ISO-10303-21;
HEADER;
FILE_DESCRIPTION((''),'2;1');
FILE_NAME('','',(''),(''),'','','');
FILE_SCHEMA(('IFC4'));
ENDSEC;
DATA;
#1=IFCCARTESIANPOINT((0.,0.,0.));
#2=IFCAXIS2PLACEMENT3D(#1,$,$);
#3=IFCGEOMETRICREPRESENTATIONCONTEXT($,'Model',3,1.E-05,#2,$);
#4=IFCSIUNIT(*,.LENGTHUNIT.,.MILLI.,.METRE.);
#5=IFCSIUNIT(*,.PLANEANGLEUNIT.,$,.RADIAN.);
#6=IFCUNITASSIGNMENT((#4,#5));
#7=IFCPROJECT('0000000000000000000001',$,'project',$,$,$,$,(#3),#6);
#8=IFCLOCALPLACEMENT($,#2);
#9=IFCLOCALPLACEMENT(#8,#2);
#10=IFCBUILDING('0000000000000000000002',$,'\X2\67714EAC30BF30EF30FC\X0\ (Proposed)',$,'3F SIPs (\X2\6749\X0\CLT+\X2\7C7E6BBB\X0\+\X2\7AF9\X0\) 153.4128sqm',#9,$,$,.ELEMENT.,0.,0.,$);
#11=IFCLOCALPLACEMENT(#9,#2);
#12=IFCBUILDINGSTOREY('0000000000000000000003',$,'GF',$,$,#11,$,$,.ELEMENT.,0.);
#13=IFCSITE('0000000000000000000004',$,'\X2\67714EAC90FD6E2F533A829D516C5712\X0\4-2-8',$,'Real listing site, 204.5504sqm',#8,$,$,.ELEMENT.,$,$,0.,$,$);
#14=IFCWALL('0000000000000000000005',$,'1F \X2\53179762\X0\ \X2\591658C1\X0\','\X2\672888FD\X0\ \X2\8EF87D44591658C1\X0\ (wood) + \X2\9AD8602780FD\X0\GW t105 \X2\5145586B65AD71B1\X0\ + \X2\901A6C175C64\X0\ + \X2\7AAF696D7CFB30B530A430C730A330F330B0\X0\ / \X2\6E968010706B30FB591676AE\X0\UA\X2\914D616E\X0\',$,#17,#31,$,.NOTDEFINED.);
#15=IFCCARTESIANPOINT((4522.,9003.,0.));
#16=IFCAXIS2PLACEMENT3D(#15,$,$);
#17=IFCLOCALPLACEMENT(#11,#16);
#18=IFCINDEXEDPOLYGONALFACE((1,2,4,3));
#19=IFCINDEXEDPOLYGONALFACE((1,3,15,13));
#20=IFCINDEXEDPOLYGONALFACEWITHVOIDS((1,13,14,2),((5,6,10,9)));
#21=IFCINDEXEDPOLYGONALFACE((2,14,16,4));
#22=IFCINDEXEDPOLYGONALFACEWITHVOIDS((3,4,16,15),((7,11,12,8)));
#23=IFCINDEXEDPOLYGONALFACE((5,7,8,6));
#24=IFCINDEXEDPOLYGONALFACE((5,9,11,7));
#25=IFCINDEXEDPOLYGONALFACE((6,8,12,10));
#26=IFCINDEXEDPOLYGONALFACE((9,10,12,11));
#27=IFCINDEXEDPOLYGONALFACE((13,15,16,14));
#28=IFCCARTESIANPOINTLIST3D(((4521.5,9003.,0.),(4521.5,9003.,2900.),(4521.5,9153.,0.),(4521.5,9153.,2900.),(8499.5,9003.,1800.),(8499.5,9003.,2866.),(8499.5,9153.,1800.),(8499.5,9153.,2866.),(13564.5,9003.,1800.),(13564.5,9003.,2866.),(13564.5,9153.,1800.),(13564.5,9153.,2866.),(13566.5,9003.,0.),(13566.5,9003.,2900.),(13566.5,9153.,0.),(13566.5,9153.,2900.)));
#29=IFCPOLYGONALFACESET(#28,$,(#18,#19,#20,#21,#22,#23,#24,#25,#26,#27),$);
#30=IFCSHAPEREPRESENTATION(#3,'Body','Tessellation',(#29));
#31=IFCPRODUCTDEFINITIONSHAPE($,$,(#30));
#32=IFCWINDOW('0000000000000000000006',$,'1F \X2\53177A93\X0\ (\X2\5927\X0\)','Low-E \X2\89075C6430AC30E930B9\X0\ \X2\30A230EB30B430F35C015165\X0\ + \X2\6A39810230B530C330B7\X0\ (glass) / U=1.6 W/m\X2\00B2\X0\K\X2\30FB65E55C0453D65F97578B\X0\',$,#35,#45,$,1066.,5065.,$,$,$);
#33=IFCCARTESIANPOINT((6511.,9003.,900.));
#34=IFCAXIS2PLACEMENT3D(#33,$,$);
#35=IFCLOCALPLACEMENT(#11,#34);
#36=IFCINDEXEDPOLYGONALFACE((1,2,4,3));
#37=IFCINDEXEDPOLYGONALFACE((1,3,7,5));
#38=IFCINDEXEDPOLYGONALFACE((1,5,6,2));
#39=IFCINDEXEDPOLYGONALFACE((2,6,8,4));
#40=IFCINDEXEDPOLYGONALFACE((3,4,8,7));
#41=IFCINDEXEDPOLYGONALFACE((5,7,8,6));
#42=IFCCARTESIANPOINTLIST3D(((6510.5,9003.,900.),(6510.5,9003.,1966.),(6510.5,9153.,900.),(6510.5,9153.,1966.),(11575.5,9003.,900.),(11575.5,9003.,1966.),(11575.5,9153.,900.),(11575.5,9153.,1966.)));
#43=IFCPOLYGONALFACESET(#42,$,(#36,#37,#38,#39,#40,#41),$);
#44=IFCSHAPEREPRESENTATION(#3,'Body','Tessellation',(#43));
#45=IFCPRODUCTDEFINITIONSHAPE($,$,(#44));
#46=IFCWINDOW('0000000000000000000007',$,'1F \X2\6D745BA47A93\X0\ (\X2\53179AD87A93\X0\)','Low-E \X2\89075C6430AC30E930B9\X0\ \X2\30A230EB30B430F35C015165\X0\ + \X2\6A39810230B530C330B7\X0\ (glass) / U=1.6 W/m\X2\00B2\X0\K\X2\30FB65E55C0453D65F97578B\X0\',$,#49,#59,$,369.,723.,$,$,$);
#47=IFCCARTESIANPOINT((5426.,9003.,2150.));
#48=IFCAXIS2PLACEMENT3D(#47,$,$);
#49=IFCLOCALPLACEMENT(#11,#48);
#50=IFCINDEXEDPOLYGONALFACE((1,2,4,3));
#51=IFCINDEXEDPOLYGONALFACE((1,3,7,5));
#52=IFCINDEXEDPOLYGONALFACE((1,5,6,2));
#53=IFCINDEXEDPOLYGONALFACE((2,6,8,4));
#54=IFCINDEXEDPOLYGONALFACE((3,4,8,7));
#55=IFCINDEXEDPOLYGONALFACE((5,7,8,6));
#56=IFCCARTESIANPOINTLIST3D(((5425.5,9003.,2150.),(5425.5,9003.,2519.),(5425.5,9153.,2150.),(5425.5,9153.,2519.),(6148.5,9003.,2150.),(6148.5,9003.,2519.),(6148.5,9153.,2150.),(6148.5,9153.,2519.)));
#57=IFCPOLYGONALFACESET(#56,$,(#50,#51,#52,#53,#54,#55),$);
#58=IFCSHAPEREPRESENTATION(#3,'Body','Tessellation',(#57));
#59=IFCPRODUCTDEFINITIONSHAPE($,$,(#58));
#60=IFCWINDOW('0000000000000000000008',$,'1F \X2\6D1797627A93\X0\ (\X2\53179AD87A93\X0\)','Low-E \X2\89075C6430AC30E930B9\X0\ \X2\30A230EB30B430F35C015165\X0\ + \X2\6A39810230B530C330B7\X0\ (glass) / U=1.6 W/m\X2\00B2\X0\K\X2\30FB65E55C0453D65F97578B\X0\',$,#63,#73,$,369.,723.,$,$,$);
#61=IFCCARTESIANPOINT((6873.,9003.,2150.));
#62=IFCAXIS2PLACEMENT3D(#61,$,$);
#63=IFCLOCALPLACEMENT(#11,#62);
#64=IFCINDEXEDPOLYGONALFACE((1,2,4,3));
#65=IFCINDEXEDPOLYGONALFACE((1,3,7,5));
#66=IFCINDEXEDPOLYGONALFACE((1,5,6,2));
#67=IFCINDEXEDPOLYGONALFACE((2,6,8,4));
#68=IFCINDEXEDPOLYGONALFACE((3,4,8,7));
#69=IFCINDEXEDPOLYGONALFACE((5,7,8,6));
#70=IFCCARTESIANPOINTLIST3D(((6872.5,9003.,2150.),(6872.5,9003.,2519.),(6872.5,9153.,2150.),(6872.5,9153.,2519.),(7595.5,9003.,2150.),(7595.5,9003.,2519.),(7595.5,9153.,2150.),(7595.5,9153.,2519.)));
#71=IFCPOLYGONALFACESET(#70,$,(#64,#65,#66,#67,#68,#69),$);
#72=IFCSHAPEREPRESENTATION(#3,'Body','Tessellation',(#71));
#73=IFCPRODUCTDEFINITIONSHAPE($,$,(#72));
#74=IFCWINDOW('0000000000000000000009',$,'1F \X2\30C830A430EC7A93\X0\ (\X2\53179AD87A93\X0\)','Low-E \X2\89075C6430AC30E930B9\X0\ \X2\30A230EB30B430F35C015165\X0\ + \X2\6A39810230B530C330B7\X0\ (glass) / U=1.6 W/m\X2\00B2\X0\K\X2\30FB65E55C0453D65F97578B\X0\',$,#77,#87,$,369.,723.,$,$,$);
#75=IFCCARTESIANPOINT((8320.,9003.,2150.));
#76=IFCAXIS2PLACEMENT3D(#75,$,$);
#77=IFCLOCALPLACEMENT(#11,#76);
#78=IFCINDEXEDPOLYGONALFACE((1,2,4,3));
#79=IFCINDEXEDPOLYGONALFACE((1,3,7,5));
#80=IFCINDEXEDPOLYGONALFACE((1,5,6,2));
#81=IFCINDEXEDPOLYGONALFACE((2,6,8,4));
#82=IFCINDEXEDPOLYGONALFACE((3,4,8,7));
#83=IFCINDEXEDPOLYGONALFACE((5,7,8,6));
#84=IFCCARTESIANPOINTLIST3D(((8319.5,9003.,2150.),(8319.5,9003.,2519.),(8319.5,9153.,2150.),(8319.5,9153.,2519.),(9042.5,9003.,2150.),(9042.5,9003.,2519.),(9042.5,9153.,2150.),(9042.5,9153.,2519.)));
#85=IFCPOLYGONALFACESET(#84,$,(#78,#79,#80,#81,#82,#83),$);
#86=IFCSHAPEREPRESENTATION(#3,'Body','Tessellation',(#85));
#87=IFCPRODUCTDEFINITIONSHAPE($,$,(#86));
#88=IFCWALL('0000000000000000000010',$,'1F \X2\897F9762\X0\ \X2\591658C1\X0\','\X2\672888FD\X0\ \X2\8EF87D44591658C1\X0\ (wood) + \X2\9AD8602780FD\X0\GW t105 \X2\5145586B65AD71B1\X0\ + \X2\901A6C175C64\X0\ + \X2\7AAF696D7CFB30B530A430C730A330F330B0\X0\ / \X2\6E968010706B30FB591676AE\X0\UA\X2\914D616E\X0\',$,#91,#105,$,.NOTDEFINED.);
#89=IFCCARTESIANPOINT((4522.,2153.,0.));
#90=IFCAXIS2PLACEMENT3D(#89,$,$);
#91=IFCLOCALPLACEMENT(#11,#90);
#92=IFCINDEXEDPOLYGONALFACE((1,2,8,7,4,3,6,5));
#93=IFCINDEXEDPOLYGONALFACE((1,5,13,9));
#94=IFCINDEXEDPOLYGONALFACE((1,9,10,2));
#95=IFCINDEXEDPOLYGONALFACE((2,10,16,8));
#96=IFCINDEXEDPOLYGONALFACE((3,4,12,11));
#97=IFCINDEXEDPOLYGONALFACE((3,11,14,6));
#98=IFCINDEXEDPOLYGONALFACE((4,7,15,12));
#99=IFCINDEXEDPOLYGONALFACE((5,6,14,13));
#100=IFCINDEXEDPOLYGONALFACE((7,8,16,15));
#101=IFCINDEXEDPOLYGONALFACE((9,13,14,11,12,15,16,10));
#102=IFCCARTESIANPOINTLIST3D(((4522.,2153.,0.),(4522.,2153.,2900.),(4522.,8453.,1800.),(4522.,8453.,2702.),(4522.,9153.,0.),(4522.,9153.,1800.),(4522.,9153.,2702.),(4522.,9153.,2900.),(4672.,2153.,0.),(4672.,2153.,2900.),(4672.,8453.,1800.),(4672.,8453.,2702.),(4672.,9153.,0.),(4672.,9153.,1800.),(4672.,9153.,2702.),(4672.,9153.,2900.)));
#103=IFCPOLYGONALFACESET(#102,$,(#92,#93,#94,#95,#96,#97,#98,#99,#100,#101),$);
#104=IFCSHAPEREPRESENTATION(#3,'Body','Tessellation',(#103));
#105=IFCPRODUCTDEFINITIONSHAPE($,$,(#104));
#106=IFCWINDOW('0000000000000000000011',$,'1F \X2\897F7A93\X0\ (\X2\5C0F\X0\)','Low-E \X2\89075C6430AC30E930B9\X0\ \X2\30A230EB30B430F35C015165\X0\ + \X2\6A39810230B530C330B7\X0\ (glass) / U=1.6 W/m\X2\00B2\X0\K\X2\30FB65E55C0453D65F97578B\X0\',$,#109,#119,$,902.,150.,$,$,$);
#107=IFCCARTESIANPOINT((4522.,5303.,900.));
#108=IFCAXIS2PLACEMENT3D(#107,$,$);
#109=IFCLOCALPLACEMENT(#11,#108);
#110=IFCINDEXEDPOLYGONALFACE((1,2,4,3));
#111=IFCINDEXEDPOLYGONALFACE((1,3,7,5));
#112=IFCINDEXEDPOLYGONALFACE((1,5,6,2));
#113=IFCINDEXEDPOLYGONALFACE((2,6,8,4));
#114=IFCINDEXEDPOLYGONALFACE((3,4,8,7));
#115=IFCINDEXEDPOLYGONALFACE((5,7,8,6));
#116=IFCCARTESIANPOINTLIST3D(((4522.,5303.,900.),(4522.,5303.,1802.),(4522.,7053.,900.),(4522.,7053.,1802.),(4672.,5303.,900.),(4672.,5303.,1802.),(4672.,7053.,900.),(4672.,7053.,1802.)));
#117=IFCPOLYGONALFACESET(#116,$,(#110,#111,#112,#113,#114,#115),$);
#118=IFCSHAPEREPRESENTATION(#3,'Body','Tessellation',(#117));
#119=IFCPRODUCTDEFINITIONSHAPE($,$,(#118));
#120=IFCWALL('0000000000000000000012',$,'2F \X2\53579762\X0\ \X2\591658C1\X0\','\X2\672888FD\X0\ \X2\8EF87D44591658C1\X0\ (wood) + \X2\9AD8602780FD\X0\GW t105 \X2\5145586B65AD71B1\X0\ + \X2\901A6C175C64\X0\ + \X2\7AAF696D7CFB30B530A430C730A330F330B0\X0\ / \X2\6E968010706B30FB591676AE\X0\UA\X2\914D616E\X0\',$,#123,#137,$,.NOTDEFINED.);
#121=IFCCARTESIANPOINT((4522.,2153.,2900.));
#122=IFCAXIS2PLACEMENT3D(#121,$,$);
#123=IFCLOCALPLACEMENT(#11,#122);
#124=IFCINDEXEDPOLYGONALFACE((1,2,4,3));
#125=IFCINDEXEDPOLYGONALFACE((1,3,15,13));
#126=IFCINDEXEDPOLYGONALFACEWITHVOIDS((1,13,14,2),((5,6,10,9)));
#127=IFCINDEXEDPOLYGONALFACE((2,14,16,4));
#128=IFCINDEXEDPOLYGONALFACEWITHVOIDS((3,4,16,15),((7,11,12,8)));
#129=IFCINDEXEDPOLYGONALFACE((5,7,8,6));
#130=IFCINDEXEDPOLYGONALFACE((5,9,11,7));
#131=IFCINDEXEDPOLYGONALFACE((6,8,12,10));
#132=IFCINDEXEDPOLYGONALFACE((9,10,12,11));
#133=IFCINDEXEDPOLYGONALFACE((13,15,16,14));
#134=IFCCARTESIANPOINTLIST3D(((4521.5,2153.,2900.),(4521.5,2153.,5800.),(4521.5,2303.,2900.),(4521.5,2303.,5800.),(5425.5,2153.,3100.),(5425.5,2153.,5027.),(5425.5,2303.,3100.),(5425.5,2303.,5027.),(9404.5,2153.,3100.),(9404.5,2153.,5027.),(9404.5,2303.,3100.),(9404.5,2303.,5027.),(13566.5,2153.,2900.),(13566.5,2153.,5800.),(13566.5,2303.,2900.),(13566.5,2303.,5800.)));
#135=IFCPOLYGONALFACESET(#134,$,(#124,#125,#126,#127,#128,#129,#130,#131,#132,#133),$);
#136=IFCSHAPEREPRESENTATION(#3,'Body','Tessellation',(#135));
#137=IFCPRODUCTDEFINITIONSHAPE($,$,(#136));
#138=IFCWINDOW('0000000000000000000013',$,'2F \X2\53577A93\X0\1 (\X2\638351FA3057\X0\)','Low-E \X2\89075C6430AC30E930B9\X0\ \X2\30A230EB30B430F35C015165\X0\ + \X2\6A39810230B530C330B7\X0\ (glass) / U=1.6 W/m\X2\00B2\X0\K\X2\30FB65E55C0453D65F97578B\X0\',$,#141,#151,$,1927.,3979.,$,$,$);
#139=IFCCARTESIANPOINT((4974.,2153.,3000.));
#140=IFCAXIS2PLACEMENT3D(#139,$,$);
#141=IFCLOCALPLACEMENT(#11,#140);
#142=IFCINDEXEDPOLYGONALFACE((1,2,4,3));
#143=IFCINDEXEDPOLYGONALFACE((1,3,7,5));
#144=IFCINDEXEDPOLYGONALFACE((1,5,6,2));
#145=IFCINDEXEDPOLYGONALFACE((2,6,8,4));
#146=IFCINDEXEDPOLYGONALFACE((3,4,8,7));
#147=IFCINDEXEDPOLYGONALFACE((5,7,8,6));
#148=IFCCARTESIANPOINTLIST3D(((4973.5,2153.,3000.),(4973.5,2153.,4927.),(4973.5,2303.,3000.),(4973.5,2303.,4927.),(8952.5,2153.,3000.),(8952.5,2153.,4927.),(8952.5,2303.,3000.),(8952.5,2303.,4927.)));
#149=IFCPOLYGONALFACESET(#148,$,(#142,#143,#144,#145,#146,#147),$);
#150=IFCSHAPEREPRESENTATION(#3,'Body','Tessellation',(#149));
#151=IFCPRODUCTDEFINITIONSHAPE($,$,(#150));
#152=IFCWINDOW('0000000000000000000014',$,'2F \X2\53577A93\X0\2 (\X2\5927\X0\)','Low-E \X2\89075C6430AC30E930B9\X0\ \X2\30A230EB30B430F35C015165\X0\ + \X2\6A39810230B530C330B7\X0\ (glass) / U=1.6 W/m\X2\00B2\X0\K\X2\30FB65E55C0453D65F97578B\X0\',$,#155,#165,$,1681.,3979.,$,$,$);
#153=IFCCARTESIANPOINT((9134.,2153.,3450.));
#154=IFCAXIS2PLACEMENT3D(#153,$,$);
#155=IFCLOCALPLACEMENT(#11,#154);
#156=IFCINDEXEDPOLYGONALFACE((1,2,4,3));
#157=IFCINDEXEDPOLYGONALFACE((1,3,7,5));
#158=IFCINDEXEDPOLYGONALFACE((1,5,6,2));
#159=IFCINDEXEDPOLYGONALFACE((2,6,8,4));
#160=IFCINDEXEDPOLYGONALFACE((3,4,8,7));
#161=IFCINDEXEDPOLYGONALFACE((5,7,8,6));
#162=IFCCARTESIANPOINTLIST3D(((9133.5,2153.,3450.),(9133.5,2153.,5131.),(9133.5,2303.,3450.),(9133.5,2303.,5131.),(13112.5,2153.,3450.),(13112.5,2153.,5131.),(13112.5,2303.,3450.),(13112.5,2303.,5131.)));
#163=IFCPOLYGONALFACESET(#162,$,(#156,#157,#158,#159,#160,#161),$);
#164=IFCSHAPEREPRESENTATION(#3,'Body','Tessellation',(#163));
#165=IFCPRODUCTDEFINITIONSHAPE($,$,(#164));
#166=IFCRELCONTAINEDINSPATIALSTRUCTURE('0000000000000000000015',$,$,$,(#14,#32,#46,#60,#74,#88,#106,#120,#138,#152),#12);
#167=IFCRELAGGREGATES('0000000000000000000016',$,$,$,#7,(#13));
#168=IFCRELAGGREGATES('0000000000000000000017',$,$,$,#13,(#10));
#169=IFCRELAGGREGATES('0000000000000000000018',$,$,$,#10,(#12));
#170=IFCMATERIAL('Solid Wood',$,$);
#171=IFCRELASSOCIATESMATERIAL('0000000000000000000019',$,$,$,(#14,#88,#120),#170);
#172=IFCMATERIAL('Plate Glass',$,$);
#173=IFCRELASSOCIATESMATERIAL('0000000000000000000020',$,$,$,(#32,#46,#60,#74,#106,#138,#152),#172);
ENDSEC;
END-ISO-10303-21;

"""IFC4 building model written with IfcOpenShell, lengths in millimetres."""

from ifc_helpers import new_model, si_unit, frame, frame_2d, origin, place, context, project, spatial, rectangle, extrude, material, element, fill, save


model = new_model("IFC4")

# Units and contexts
model_context = context("Model", 3, precision=1e-05, world=origin())
ifc_project = project(units=[si_unit("LENGTHUNIT", "METRE", prefix="MILLI"), si_unit("PLANEANGLEUNIT", "RADIAN")], contexts=[model_context])

# Site, building, storey
site_placement = place(None, origin())
site = spatial("IfcSite", under=ifc_project, at=site_placement, Name="東京都港区芝公園4-2-8", ObjectType="Real listing site, 204.5504sqm", CompositionType="ELEMENT", RefElevation=0.0)
building_placement = place(site_placement, origin())
building = spatial("IfcBuilding", under=site, at=building_placement, Name="東京タワー (Proposed)", ObjectType="3F SIPs (杉CLT+籾殻+竹) 153.4128sqm", CompositionType="ELEMENT", ElevationOfRefHeight=0.0, ElevationOfTerrain=0.0)
storey_placement = place(building_placement, origin())
storey = spatial("IfcBuildingStorey", under=building, at=storey_placement, Name="GF", CompositionType="ELEMENT", Elevation=0.0)

# Shared definitions
ifc_material_1 = material(Name="Solid Wood")

# Shared definitions
ifc_material_2 = material(Name="Plate Glass")

# Wall, openings, windows
wall_1_placement = place(storey_placement, frame((4522.0, 9003.0, 0.0)))
wall_1 = element("IfcWall", 1, at=wall_1_placement, inside=storey, material=ifc_material_1, Name="1F 北面 外壁", Description="木製 軸組外壁 (wood) + 高性能GW t105 充填断熱 + 通気層 + 窯業系サイディング / 準耐火・外皮UA配慮", PredefinedType="NOTDEFINED", context=model_context, shape_type="SweptSolid", body=[
    extrude(rectangle(XDim=9045.0, YDim=150.0, at=frame_2d((4522.0, 75.0))), frame((4522.0, 9003.0, 0.0)), (0.0, 0.0, 1.0), 2900.0),
])
opening_1_placement = place(storey_placement, frame((6511.0, 9003.0, 900.0)))
opening_1 = element("IfcOpeningElement", 2, at=opening_1_placement, cuts=wall_1, PredefinedType="NOTDEFINED", context=model_context, shape_type="SweptSolid", body=[
    extrude(rectangle(XDim=5065.0, YDim=150.0, at=frame_2d((2532.0, 75.0))), frame((6511.0, 9003.0, 900.0)), (0.0, 0.0, 1.0), 1066.0),
])
opening_2_placement = place(storey_placement, frame((5426.0, 9003.0, 2150.0)))
opening_2 = element("IfcOpeningElement", 3, at=opening_2_placement, cuts=wall_1, PredefinedType="NOTDEFINED", context=model_context, shape_type="SweptSolid", body=[
    extrude(rectangle(XDim=723.0, YDim=150.0, at=frame_2d((361.0, 75.0))), frame((5426.0, 9003.0, 2150.0)), (0.0, 0.0, 1.0), 369.0),
])
opening_3_placement = place(storey_placement, frame((6873.0, 9003.0, 2150.0)))
opening_3 = element("IfcOpeningElement", 4, at=opening_3_placement, cuts=wall_1, PredefinedType="NOTDEFINED", context=model_context, shape_type="SweptSolid", body=[
    extrude(rectangle(XDim=723.0, YDim=150.0, at=frame_2d((361.0, 75.0))), frame((6873.0, 9003.0, 2150.0)), (0.0, 0.0, 1.0), 369.0),
])
opening_4_placement = place(storey_placement, frame((8320.0, 9003.0, 2150.0)))
opening_4 = element("IfcOpeningElement", 5, at=opening_4_placement, cuts=wall_1, PredefinedType="NOTDEFINED", context=model_context, shape_type="SweptSolid", body=[
    extrude(rectangle(XDim=723.0, YDim=150.0, at=frame_2d((361.0, 75.0))), frame((8320.0, 9003.0, 2150.0)), (0.0, 0.0, 1.0), 369.0),
])
window_1_placement = place(storey_placement, frame((6511.0, 9003.0, 900.0)))
window_1 = element("IfcWindow", 6, at=window_1_placement, inside=storey, material=ifc_material_2, Name="1F 北窓 (大)", Description="Low-E 複層ガラス アルゴン封入 + 樹脂サッシ (glass) / U=1.6 W/m²K・日射取得型", OverallHeight=1066.0, OverallWidth=5065.0, context=model_context, shape_type="SweptSolid", body=[
    extrude(rectangle(XDim=5065.0, YDim=150.0, at=frame_2d((2532.0, 75.0))), frame((6511.0, 9003.0, 900.0)), (0.0, 0.0, 1.0), 1066.0),
])
fill(opening_1, window_1)
window_2_placement = place(storey_placement, frame((5426.0, 9003.0, 2150.0)))
window_2 = element("IfcWindow", 7, at=window_2_placement, inside=storey, material=ifc_material_2, Name="1F 浴室窓 (北高窓)", Description="Low-E 複層ガラス アルゴン封入 + 樹脂サッシ (glass) / U=1.6 W/m²K・日射取得型", OverallHeight=369.0, OverallWidth=723.0, context=model_context, shape_type="SweptSolid", body=[
    extrude(rectangle(XDim=723.0, YDim=150.0, at=frame_2d((361.0, 75.0))), frame((5426.0, 9003.0, 2150.0)), (0.0, 0.0, 1.0), 369.0),
])
fill(opening_2, window_2)
window_3_placement = place(storey_placement, frame((6873.0, 9003.0, 2150.0)))
window_3 = element("IfcWindow", 8, at=window_3_placement, inside=storey, material=ifc_material_2, Name="1F 洗面窓 (北高窓)", Description="Low-E 複層ガラス アルゴン封入 + 樹脂サッシ (glass) / U=1.6 W/m²K・日射取得型", OverallHeight=369.0, OverallWidth=723.0, context=model_context, shape_type="SweptSolid", body=[
    extrude(rectangle(XDim=723.0, YDim=150.0, at=frame_2d((361.0, 75.0))), frame((6873.0, 9003.0, 2150.0)), (0.0, 0.0, 1.0), 369.0),
])
fill(opening_3, window_3)
window_4_placement = place(storey_placement, frame((8320.0, 9003.0, 2150.0)))
window_4 = element("IfcWindow", 9, at=window_4_placement, inside=storey, material=ifc_material_2, Name="1F トイレ窓 (北高窓)", Description="Low-E 複層ガラス アルゴン封入 + 樹脂サッシ (glass) / U=1.6 W/m²K・日射取得型", OverallHeight=369.0, OverallWidth=723.0, context=model_context, shape_type="SweptSolid", body=[
    extrude(rectangle(XDim=723.0, YDim=150.0, at=frame_2d((361.0, 75.0))), frame((8320.0, 9003.0, 2150.0)), (0.0, 0.0, 1.0), 369.0),
])
fill(opening_4, window_4)

# Wall, opening, window
wall_2_placement = place(storey_placement, frame((4522.0, 2153.0, 0.0)))
wall_2 = element("IfcWall", 10, at=wall_2_placement, inside=storey, material=ifc_material_1, Name="1F 西面 外壁", Description="木製 軸組外壁 (wood) + 高性能GW t105 充填断熱 + 通気層 + 窯業系サイディング / 準耐火・外皮UA配慮", PredefinedType="NOTDEFINED", context=model_context, shape_type="SweptSolid", body=[
    extrude(rectangle(XDim=150.0, YDim=7000.0, at=frame_2d((75.0, 3500.0))), frame((4522.0, 2153.0, 0.0)), (0.0, 0.0, 1.0), 2900.0),
])
opening_5_placement = place(storey_placement, frame((4522.0, 5303.0, 900.0)))
opening_5 = element("IfcOpeningElement", 11, at=opening_5_placement, cuts=wall_2, PredefinedType="NOTDEFINED", context=model_context, shape_type="SweptSolid", body=[
    extrude(rectangle(XDim=150.0, YDim=1750.0, at=frame_2d((75.0, 875.0))), frame((4522.0, 5303.0, 900.0)), (0.0, 0.0, 1.0), 902.0),
])
window_5_placement = place(storey_placement, frame((4522.0, 5303.0, 900.0)))
window_5 = element("IfcWindow", 12, at=window_5_placement, inside=storey, material=ifc_material_2, Name="1F 西窓 (小)", Description="Low-E 複層ガラス アルゴン封入 + 樹脂サッシ (glass) / U=1.6 W/m²K・日射取得型", OverallHeight=902.0, OverallWidth=150.0, context=model_context, shape_type="SweptSolid", body=[
    extrude(rectangle(XDim=150.0, YDim=1750.0, at=frame_2d((75.0, 875.0))), frame((4522.0, 5303.0, 900.0)), (0.0, 0.0, 1.0), 902.0),
])
fill(opening_5, window_5)

# Wall, openings, windows
wall_3_placement = place(storey_placement, frame((4522.0, 2153.0, 2900.0)))
wall_3 = element("IfcWall", 13, at=wall_3_placement, inside=storey, material=ifc_material_1, Name="2F 南面 外壁", Description="木製 軸組外壁 (wood) + 高性能GW t105 充填断熱 + 通気層 + 窯業系サイディング / 準耐火・外皮UA配慮", PredefinedType="NOTDEFINED", context=model_context, shape_type="SweptSolid", body=[
    extrude(rectangle(XDim=9045.0, YDim=150.0, at=frame_2d((4522.0, 75.0))), frame((4522.0, 2153.0, 2900.0)), (0.0, 0.0, 1.0), 2900.0),
])
opening_6_placement = place(storey_placement, frame((4974.0, 2153.0, 3000.0)))
opening_6 = element("IfcOpeningElement", 14, at=opening_6_placement, cuts=wall_3, PredefinedType="NOTDEFINED", context=model_context, shape_type="SweptSolid", body=[
    extrude(rectangle(XDim=3979.0, YDim=150.0, at=frame_2d((1989.0, 75.0))), frame((4974.0, 2153.0, 3000.0)), (0.0, 0.0, 1.0), 1927.0),
])
opening_7_placement = place(storey_placement, frame((9134.0, 2153.0, 3450.0)))
opening_7 = element("IfcOpeningElement", 15, at=opening_7_placement, cuts=wall_3, PredefinedType="NOTDEFINED", context=model_context, shape_type="SweptSolid", body=[
    extrude(rectangle(XDim=3979.0, YDim=150.0, at=frame_2d((1989.0, 75.0))), frame((9134.0, 2153.0, 3450.0)), (0.0, 0.0, 1.0), 1681.0),
])
window_6_placement = place(storey_placement, frame((4974.0, 2153.0, 3000.0)))
window_6 = element("IfcWindow", 16, at=window_6_placement, inside=storey, material=ifc_material_2, Name="2F 南窓1 (掃出し)", Description="Low-E 複層ガラス アルゴン封入 + 樹脂サッシ (glass) / U=1.6 W/m²K・日射取得型", OverallHeight=1927.0, OverallWidth=3979.0, context=model_context, shape_type="SweptSolid", body=[
    extrude(rectangle(XDim=3979.0, YDim=150.0, at=frame_2d((1989.0, 75.0))), frame((4974.0, 2153.0, 3000.0)), (0.0, 0.0, 1.0), 1927.0),
])
fill(opening_6, window_6)
window_7_placement = place(storey_placement, frame((9134.0, 2153.0, 3450.0)))
window_7 = element("IfcWindow", 17, at=window_7_placement, inside=storey, material=ifc_material_2, Name="2F 南窓2 (大)", Description="Low-E 複層ガラス アルゴン封入 + 樹脂サッシ (glass) / U=1.6 W/m²K・日射取得型", OverallHeight=1681.0, OverallWidth=3979.0, context=model_context, shape_type="SweptSolid", body=[
    extrude(rectangle(XDim=3979.0, YDim=150.0, at=frame_2d((1989.0, 75.0))), frame((9134.0, 2153.0, 3450.0)), (0.0, 0.0, 1.0), 1681.0),
])
fill(opening_7, window_7)

save(model, "model.ifc")
